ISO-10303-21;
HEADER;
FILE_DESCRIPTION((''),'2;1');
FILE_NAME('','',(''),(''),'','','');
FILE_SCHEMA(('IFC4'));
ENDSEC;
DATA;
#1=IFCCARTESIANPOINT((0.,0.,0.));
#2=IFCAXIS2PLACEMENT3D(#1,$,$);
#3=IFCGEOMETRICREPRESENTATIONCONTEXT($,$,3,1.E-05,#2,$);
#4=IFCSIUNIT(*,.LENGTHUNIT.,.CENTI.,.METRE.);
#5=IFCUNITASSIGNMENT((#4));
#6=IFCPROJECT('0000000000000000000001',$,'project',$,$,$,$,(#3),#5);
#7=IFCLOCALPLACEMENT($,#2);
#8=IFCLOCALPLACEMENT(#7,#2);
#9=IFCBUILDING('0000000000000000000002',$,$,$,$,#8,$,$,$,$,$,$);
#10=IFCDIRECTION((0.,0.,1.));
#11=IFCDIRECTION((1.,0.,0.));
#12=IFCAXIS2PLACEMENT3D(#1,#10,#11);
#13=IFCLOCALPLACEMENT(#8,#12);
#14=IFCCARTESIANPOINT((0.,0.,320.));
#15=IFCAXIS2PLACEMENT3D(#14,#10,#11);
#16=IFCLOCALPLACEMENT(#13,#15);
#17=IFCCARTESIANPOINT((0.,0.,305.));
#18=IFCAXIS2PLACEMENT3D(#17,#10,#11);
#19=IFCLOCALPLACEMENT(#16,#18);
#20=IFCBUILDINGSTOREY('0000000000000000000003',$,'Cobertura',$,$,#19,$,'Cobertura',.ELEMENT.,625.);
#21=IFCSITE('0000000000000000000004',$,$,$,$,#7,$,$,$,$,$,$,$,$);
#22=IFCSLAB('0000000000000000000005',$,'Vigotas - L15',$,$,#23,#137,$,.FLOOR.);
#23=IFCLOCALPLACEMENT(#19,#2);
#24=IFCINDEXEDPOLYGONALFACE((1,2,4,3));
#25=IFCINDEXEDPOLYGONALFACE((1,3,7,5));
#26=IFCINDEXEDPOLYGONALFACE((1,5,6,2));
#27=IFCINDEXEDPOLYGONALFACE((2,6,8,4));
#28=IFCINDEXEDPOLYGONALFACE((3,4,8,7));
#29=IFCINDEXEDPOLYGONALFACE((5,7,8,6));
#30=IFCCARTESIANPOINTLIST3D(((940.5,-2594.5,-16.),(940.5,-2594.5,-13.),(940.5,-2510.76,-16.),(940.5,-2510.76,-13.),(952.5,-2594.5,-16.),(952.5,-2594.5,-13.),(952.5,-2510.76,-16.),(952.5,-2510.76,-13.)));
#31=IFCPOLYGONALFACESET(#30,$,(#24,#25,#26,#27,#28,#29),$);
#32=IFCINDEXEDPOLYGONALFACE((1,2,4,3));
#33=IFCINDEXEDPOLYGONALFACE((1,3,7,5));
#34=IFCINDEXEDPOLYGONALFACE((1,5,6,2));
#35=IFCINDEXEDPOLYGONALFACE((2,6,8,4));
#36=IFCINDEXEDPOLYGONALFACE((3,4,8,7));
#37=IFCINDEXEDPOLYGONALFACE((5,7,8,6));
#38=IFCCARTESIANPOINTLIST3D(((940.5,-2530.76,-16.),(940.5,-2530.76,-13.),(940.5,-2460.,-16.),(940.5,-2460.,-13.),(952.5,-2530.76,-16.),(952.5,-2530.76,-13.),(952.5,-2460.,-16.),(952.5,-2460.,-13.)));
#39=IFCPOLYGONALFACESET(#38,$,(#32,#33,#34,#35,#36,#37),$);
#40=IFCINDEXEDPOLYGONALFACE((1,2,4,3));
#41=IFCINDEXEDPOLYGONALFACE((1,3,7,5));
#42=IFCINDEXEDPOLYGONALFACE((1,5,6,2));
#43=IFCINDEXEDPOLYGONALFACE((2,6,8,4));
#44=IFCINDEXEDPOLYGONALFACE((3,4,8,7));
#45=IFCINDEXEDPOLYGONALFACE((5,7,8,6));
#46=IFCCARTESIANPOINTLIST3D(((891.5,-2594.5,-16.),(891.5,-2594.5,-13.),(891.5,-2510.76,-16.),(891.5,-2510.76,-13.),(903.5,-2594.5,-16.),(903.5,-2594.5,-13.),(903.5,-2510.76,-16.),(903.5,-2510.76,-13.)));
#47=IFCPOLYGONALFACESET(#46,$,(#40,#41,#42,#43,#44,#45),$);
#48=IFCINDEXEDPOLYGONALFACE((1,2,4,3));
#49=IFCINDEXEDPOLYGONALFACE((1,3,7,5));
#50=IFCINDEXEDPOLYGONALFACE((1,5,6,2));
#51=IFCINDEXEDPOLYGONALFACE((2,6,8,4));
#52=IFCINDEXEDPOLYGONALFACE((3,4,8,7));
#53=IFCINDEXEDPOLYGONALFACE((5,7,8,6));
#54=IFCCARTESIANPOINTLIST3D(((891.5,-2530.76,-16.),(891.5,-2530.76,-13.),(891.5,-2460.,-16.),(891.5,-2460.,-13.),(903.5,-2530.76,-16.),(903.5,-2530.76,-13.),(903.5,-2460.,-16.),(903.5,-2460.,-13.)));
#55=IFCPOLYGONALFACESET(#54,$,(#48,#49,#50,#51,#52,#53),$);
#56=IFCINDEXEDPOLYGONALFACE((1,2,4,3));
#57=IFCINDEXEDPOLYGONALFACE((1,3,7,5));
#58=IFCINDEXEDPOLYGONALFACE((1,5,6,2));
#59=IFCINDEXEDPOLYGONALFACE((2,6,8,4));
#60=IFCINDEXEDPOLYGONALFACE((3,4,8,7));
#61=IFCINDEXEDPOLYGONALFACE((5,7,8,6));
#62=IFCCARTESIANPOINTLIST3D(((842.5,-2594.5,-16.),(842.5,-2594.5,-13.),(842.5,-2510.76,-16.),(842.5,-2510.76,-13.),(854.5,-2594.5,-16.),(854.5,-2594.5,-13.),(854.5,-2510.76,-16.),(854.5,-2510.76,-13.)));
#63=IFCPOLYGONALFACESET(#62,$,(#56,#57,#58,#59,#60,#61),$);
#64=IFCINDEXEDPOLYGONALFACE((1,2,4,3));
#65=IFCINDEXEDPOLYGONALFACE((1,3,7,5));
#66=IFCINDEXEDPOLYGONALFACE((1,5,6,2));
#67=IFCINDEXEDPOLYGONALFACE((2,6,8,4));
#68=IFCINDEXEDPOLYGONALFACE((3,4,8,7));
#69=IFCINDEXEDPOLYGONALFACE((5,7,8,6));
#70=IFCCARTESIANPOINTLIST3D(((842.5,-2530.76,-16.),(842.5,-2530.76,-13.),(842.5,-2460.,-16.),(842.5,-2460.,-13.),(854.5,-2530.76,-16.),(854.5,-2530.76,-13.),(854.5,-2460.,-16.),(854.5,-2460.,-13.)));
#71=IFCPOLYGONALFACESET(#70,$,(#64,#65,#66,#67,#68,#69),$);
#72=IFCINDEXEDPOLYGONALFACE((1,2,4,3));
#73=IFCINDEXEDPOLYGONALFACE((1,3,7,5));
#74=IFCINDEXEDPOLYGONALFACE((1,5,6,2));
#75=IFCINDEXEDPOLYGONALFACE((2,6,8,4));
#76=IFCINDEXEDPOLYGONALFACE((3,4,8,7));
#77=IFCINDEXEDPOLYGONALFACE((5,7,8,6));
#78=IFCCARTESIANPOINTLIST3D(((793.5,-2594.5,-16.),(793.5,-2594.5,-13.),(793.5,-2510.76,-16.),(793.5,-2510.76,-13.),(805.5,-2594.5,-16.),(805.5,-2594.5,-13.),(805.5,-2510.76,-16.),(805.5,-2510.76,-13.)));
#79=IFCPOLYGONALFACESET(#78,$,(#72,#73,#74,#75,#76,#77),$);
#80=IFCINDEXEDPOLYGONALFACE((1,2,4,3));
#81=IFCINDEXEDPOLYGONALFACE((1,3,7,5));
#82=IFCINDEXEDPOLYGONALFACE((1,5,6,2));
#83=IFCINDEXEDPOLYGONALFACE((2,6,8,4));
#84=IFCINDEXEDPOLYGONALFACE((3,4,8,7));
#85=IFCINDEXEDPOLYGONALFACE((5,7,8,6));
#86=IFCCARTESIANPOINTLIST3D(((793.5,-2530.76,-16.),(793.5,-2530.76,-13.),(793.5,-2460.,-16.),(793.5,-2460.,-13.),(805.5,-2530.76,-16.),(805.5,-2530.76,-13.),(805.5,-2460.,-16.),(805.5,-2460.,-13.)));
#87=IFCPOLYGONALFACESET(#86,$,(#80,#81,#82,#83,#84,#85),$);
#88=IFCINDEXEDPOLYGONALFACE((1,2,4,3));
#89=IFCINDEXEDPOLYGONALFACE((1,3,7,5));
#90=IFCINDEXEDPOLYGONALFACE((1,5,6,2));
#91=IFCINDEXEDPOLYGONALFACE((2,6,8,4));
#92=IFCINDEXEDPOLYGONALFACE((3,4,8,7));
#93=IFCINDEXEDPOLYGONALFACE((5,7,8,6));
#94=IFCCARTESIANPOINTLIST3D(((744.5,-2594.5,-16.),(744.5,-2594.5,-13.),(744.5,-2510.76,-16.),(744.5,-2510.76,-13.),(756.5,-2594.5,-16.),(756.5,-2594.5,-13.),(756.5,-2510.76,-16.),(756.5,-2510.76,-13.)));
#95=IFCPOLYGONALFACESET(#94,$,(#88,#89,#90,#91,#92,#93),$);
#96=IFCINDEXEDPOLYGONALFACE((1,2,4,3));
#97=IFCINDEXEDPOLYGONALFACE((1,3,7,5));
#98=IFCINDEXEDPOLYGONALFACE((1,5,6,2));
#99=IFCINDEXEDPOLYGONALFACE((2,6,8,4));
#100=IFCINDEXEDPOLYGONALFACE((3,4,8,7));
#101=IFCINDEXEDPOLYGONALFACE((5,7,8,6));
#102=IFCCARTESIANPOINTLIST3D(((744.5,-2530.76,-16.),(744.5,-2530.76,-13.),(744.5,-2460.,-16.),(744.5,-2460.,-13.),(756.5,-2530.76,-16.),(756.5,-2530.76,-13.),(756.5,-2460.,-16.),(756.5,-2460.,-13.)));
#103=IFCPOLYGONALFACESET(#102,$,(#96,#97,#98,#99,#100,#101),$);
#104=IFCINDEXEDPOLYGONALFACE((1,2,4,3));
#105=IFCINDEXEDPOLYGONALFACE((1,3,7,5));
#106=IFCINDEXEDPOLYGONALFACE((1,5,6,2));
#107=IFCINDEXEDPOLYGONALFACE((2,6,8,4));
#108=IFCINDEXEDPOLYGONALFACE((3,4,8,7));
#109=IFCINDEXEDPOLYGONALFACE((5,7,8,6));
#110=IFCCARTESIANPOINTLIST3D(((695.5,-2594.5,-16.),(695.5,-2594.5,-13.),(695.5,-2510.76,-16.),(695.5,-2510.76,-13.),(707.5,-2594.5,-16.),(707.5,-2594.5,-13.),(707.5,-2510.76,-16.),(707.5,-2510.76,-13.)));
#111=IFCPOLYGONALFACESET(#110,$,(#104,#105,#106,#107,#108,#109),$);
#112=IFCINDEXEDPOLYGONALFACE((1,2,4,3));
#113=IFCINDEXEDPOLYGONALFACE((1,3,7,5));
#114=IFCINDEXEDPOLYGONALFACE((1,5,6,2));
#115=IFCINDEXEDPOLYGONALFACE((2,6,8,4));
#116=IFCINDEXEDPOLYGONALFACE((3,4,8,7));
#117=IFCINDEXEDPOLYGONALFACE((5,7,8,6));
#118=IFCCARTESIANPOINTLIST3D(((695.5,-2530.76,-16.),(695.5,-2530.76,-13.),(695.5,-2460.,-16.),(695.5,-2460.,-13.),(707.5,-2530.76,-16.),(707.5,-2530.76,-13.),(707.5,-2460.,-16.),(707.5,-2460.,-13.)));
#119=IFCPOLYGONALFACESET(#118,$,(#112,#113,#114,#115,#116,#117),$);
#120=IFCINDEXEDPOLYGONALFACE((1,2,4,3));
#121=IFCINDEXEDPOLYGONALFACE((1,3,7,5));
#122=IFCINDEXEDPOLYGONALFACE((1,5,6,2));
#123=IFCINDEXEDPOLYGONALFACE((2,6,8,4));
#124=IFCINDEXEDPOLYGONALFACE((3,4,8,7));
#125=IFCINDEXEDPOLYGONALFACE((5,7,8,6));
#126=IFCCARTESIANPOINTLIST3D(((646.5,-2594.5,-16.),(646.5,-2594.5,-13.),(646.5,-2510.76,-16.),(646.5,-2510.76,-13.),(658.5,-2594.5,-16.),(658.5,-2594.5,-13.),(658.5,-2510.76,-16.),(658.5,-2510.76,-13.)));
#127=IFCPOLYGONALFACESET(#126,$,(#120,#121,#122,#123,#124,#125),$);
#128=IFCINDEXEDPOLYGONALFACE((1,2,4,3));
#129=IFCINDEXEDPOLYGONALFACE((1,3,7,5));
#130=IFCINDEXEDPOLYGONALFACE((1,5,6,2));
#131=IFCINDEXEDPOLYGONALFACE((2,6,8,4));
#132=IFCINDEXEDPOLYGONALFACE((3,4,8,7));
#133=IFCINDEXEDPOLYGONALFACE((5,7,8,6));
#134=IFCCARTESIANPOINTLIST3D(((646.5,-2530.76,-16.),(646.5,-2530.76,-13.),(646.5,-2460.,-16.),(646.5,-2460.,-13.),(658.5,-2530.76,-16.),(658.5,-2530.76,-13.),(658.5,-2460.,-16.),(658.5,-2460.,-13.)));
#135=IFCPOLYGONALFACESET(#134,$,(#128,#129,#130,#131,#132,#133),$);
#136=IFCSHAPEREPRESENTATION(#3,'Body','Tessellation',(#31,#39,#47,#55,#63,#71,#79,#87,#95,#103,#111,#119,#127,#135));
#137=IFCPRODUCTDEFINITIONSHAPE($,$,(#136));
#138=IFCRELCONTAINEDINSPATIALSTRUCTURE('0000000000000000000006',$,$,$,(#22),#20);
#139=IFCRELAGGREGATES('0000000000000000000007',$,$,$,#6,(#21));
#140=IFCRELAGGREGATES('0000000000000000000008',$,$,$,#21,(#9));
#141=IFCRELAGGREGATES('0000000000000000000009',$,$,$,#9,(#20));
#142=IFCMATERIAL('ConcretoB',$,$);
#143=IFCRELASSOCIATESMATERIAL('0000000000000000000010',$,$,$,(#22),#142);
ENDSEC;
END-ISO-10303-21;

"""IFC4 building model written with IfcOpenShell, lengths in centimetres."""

from ifc_helpers import new_model, si_unit, frame, origin, origin_with_axes, place, context, project, spatial, polyline, outline, extrude, material, element, save


model = new_model("IFC4")

# Units and contexts
context_of_model = context(None, 3, precision=1e-05, world=origin())
ifc_project = project(units=[si_unit("LENGTHUNIT", "METRE", prefix="CENTI")], contexts=[context_of_model])

# Site, building, storey
site_placement = place(None, origin())
site = spatial("IfcSite", under=ifc_project, at=site_placement)
building_placement = place(site_placement, origin())
building = spatial("IfcBuilding", under=site, at=building_placement)
placement_1 = place(building_placement, origin_with_axes())
placement_2 = place(placement_1, frame((0.0, 0.0, 320.0), z_axis=(0.0, 0.0, 1.0), x_axis=(1.0, 0.0, 0.0)))
storey_placement = place(placement_2, frame((0.0, 0.0, 305.0), z_axis=(0.0, 0.0, 1.0), x_axis=(1.0, 0.0, 0.0)))
storey = spatial("IfcBuildingStorey", under=building, at=storey_placement, Name="Cobertura", LongName="Cobertura", CompositionType="ELEMENT", Elevation=625.0)

# Shared definitions
ifc_material = material(Name="ConcretoB")

# Slab
slab_1_placement = place(storey_placement, frame((799.5, -2527.25, -13.0), z_axis=(0.0, 0.0, 1.0), x_axis=(1.0, 0.0, 0.0)))
element("IfcSlab", 1, at=slab_1_placement, inside=storey, material=ifc_material, Name="Vigotas - L15", PredefinedType="FLOOR", context=context_of_model, shape_type="SolidModel", body=[
    extrude(outline(polyline([(6.0, 1.5), (-6.0, 1.5), (-6.0, -1.5), (6.0, -1.5), (6.0, 1.5), (6.0, 1.5)])), frame((147.0, -67.25, -1.5), z_axis=(0.0, 1.0, 0.0), x_axis=(1.0, 0.0, 0.0)), (0.0, 0.0, 1.0), 83.74),
    extrude(outline(polyline([(6.0, 1.5), (-6.0, 1.5), (-6.0, -1.5), (6.0, -1.5), (6.0, 1.5), (6.0, 1.5)])), frame((147.0, -3.51, -1.5), z_axis=(0.0, 1.0, 0.0), x_axis=(1.0, 0.0, 0.0)), (0.0, 0.0, 1.0), 70.76),
    extrude(outline(polyline([(6.0, 1.5), (-6.0, 1.5), (-6.0, -1.5), (6.0, -1.5), (6.0, 1.5), (6.0, 1.5)])), frame((98.0, -67.25, -1.5), z_axis=(0.0, 1.0, 0.0), x_axis=(1.0, 0.0, 0.0)), (0.0, 0.0, 1.0), 83.74),
    extrude(outline(polyline([(6.0, 1.5), (-6.0, 1.5), (-6.0, -1.5), (6.0, -1.5), (6.0, 1.5), (6.0, 1.5)])), frame((98.0, -3.51, -1.5), z_axis=(0.0, 1.0, 0.0), x_axis=(1.0, 0.0, 0.0)), (0.0, 0.0, 1.0), 70.76),
    extrude(outline(polyline([(6.0, 1.5), (-6.0, 1.5), (-6.0, -1.5), (6.0, -1.5), (6.0, 1.5), (6.0, 1.5)])), frame((49.0, -67.25, -1.5), z_axis=(0.0, 1.0, 0.0), x_axis=(1.0, 0.0, 0.0)), (0.0, 0.0, 1.0), 83.74),
    extrude(outline(polyline([(6.0, 1.5), (-6.0, 1.5), (-6.0, -1.5), (6.0, -1.5), (6.0, 1.5), (6.0, 1.5)])), frame((49.0, -3.51, -1.5), z_axis=(0.0, 1.0, 0.0), x_axis=(1.0, 0.0, 0.0)), (0.0, 0.0, 1.0), 70.76),
    extrude(outline(polyline([(6.0, 1.5), (-6.0, 1.5), (-6.0, -1.5), (6.0, -1.5), (6.0, 1.5), (6.0, 1.5)])), frame((0.0, -67.25, -1.5), z_axis=(0.0, 1.0, 0.0), x_axis=(1.0, 0.0, 0.0)), (0.0, 0.0, 1.0), 83.74),
    extrude(outline(polyline([(6.0, 1.5), (-6.0, 1.5), (-6.0, -1.5), (6.0, -1.5), (6.0, 1.5), (6.0, 1.5)])), frame((0.0, -3.51, -1.5), z_axis=(0.0, 1.0, 0.0), x_axis=(1.0, 0.0, 0.0)), (0.0, 0.0, 1.0), 70.76),
    extrude(outline(polyline([(6.0, 1.5), (-6.0, 1.5), (-6.0, -1.5), (6.0, -1.5), (6.0, 1.5), (6.0, 1.5)])), frame((-49.0, -67.25, -1.5), z_axis=(0.0, 1.0, 0.0), x_axis=(1.0, 0.0, 0.0)), (0.0, 0.0, 1.0), 83.74),
    extrude(outline(polyline([(6.0, 1.5), (-6.0, 1.5), (-6.0, -1.5), (6.0, -1.5), (6.0, 1.5), (6.0, 1.5)])), frame((-49.0, -3.51, -1.5), z_axis=(0.0, 1.0, 0.0), x_axis=(1.0, 0.0, 0.0)), (0.0, 0.0, 1.0), 70.76),
    extrude(outline(polyline([(6.0, 1.5), (-6.0, 1.5), (-6.0, -1.5), (6.0, -1.5), (6.0, 1.5), (6.0, 1.5)])), frame((-98.0, -67.25, -1.5), z_axis=(0.0, 1.0, 0.0), x_axis=(1.0, 0.0, 0.0)), (0.0, 0.0, 1.0), 83.74),
    extrude(outline(polyline([(6.0, 1.5), (-6.0, 1.5), (-6.0, -1.5), (6.0, -1.5), (6.0, 1.5), (6.0, 1.5)])), frame((-98.0, -3.51, -1.5), z_axis=(0.0, 1.0, 0.0), x_axis=(1.0, 0.0, 0.0)), (0.0, 0.0, 1.0), 70.76),
    extrude(outline(polyline([(6.0, 1.5), (-6.0, 1.5), (-6.0, -1.5), (6.0, -1.5), (6.0, 1.5), (6.0, 1.5)])), frame((-147.0, -67.25, -1.5), z_axis=(0.0, 1.0, 0.0), x_axis=(1.0, 0.0, 0.0)), (0.0, 0.0, 1.0), 83.74),
    extrude(outline(polyline([(6.0, 1.5), (-6.0, 1.5), (-6.0, -1.5), (6.0, -1.5), (6.0, 1.5), (6.0, 1.5)])), frame((-147.0, -3.51, -1.5), z_axis=(0.0, 1.0, 0.0), x_axis=(1.0, 0.0, 0.0)), (0.0, 0.0, 1.0), 70.76),
])

save(model, "model.ifc")
